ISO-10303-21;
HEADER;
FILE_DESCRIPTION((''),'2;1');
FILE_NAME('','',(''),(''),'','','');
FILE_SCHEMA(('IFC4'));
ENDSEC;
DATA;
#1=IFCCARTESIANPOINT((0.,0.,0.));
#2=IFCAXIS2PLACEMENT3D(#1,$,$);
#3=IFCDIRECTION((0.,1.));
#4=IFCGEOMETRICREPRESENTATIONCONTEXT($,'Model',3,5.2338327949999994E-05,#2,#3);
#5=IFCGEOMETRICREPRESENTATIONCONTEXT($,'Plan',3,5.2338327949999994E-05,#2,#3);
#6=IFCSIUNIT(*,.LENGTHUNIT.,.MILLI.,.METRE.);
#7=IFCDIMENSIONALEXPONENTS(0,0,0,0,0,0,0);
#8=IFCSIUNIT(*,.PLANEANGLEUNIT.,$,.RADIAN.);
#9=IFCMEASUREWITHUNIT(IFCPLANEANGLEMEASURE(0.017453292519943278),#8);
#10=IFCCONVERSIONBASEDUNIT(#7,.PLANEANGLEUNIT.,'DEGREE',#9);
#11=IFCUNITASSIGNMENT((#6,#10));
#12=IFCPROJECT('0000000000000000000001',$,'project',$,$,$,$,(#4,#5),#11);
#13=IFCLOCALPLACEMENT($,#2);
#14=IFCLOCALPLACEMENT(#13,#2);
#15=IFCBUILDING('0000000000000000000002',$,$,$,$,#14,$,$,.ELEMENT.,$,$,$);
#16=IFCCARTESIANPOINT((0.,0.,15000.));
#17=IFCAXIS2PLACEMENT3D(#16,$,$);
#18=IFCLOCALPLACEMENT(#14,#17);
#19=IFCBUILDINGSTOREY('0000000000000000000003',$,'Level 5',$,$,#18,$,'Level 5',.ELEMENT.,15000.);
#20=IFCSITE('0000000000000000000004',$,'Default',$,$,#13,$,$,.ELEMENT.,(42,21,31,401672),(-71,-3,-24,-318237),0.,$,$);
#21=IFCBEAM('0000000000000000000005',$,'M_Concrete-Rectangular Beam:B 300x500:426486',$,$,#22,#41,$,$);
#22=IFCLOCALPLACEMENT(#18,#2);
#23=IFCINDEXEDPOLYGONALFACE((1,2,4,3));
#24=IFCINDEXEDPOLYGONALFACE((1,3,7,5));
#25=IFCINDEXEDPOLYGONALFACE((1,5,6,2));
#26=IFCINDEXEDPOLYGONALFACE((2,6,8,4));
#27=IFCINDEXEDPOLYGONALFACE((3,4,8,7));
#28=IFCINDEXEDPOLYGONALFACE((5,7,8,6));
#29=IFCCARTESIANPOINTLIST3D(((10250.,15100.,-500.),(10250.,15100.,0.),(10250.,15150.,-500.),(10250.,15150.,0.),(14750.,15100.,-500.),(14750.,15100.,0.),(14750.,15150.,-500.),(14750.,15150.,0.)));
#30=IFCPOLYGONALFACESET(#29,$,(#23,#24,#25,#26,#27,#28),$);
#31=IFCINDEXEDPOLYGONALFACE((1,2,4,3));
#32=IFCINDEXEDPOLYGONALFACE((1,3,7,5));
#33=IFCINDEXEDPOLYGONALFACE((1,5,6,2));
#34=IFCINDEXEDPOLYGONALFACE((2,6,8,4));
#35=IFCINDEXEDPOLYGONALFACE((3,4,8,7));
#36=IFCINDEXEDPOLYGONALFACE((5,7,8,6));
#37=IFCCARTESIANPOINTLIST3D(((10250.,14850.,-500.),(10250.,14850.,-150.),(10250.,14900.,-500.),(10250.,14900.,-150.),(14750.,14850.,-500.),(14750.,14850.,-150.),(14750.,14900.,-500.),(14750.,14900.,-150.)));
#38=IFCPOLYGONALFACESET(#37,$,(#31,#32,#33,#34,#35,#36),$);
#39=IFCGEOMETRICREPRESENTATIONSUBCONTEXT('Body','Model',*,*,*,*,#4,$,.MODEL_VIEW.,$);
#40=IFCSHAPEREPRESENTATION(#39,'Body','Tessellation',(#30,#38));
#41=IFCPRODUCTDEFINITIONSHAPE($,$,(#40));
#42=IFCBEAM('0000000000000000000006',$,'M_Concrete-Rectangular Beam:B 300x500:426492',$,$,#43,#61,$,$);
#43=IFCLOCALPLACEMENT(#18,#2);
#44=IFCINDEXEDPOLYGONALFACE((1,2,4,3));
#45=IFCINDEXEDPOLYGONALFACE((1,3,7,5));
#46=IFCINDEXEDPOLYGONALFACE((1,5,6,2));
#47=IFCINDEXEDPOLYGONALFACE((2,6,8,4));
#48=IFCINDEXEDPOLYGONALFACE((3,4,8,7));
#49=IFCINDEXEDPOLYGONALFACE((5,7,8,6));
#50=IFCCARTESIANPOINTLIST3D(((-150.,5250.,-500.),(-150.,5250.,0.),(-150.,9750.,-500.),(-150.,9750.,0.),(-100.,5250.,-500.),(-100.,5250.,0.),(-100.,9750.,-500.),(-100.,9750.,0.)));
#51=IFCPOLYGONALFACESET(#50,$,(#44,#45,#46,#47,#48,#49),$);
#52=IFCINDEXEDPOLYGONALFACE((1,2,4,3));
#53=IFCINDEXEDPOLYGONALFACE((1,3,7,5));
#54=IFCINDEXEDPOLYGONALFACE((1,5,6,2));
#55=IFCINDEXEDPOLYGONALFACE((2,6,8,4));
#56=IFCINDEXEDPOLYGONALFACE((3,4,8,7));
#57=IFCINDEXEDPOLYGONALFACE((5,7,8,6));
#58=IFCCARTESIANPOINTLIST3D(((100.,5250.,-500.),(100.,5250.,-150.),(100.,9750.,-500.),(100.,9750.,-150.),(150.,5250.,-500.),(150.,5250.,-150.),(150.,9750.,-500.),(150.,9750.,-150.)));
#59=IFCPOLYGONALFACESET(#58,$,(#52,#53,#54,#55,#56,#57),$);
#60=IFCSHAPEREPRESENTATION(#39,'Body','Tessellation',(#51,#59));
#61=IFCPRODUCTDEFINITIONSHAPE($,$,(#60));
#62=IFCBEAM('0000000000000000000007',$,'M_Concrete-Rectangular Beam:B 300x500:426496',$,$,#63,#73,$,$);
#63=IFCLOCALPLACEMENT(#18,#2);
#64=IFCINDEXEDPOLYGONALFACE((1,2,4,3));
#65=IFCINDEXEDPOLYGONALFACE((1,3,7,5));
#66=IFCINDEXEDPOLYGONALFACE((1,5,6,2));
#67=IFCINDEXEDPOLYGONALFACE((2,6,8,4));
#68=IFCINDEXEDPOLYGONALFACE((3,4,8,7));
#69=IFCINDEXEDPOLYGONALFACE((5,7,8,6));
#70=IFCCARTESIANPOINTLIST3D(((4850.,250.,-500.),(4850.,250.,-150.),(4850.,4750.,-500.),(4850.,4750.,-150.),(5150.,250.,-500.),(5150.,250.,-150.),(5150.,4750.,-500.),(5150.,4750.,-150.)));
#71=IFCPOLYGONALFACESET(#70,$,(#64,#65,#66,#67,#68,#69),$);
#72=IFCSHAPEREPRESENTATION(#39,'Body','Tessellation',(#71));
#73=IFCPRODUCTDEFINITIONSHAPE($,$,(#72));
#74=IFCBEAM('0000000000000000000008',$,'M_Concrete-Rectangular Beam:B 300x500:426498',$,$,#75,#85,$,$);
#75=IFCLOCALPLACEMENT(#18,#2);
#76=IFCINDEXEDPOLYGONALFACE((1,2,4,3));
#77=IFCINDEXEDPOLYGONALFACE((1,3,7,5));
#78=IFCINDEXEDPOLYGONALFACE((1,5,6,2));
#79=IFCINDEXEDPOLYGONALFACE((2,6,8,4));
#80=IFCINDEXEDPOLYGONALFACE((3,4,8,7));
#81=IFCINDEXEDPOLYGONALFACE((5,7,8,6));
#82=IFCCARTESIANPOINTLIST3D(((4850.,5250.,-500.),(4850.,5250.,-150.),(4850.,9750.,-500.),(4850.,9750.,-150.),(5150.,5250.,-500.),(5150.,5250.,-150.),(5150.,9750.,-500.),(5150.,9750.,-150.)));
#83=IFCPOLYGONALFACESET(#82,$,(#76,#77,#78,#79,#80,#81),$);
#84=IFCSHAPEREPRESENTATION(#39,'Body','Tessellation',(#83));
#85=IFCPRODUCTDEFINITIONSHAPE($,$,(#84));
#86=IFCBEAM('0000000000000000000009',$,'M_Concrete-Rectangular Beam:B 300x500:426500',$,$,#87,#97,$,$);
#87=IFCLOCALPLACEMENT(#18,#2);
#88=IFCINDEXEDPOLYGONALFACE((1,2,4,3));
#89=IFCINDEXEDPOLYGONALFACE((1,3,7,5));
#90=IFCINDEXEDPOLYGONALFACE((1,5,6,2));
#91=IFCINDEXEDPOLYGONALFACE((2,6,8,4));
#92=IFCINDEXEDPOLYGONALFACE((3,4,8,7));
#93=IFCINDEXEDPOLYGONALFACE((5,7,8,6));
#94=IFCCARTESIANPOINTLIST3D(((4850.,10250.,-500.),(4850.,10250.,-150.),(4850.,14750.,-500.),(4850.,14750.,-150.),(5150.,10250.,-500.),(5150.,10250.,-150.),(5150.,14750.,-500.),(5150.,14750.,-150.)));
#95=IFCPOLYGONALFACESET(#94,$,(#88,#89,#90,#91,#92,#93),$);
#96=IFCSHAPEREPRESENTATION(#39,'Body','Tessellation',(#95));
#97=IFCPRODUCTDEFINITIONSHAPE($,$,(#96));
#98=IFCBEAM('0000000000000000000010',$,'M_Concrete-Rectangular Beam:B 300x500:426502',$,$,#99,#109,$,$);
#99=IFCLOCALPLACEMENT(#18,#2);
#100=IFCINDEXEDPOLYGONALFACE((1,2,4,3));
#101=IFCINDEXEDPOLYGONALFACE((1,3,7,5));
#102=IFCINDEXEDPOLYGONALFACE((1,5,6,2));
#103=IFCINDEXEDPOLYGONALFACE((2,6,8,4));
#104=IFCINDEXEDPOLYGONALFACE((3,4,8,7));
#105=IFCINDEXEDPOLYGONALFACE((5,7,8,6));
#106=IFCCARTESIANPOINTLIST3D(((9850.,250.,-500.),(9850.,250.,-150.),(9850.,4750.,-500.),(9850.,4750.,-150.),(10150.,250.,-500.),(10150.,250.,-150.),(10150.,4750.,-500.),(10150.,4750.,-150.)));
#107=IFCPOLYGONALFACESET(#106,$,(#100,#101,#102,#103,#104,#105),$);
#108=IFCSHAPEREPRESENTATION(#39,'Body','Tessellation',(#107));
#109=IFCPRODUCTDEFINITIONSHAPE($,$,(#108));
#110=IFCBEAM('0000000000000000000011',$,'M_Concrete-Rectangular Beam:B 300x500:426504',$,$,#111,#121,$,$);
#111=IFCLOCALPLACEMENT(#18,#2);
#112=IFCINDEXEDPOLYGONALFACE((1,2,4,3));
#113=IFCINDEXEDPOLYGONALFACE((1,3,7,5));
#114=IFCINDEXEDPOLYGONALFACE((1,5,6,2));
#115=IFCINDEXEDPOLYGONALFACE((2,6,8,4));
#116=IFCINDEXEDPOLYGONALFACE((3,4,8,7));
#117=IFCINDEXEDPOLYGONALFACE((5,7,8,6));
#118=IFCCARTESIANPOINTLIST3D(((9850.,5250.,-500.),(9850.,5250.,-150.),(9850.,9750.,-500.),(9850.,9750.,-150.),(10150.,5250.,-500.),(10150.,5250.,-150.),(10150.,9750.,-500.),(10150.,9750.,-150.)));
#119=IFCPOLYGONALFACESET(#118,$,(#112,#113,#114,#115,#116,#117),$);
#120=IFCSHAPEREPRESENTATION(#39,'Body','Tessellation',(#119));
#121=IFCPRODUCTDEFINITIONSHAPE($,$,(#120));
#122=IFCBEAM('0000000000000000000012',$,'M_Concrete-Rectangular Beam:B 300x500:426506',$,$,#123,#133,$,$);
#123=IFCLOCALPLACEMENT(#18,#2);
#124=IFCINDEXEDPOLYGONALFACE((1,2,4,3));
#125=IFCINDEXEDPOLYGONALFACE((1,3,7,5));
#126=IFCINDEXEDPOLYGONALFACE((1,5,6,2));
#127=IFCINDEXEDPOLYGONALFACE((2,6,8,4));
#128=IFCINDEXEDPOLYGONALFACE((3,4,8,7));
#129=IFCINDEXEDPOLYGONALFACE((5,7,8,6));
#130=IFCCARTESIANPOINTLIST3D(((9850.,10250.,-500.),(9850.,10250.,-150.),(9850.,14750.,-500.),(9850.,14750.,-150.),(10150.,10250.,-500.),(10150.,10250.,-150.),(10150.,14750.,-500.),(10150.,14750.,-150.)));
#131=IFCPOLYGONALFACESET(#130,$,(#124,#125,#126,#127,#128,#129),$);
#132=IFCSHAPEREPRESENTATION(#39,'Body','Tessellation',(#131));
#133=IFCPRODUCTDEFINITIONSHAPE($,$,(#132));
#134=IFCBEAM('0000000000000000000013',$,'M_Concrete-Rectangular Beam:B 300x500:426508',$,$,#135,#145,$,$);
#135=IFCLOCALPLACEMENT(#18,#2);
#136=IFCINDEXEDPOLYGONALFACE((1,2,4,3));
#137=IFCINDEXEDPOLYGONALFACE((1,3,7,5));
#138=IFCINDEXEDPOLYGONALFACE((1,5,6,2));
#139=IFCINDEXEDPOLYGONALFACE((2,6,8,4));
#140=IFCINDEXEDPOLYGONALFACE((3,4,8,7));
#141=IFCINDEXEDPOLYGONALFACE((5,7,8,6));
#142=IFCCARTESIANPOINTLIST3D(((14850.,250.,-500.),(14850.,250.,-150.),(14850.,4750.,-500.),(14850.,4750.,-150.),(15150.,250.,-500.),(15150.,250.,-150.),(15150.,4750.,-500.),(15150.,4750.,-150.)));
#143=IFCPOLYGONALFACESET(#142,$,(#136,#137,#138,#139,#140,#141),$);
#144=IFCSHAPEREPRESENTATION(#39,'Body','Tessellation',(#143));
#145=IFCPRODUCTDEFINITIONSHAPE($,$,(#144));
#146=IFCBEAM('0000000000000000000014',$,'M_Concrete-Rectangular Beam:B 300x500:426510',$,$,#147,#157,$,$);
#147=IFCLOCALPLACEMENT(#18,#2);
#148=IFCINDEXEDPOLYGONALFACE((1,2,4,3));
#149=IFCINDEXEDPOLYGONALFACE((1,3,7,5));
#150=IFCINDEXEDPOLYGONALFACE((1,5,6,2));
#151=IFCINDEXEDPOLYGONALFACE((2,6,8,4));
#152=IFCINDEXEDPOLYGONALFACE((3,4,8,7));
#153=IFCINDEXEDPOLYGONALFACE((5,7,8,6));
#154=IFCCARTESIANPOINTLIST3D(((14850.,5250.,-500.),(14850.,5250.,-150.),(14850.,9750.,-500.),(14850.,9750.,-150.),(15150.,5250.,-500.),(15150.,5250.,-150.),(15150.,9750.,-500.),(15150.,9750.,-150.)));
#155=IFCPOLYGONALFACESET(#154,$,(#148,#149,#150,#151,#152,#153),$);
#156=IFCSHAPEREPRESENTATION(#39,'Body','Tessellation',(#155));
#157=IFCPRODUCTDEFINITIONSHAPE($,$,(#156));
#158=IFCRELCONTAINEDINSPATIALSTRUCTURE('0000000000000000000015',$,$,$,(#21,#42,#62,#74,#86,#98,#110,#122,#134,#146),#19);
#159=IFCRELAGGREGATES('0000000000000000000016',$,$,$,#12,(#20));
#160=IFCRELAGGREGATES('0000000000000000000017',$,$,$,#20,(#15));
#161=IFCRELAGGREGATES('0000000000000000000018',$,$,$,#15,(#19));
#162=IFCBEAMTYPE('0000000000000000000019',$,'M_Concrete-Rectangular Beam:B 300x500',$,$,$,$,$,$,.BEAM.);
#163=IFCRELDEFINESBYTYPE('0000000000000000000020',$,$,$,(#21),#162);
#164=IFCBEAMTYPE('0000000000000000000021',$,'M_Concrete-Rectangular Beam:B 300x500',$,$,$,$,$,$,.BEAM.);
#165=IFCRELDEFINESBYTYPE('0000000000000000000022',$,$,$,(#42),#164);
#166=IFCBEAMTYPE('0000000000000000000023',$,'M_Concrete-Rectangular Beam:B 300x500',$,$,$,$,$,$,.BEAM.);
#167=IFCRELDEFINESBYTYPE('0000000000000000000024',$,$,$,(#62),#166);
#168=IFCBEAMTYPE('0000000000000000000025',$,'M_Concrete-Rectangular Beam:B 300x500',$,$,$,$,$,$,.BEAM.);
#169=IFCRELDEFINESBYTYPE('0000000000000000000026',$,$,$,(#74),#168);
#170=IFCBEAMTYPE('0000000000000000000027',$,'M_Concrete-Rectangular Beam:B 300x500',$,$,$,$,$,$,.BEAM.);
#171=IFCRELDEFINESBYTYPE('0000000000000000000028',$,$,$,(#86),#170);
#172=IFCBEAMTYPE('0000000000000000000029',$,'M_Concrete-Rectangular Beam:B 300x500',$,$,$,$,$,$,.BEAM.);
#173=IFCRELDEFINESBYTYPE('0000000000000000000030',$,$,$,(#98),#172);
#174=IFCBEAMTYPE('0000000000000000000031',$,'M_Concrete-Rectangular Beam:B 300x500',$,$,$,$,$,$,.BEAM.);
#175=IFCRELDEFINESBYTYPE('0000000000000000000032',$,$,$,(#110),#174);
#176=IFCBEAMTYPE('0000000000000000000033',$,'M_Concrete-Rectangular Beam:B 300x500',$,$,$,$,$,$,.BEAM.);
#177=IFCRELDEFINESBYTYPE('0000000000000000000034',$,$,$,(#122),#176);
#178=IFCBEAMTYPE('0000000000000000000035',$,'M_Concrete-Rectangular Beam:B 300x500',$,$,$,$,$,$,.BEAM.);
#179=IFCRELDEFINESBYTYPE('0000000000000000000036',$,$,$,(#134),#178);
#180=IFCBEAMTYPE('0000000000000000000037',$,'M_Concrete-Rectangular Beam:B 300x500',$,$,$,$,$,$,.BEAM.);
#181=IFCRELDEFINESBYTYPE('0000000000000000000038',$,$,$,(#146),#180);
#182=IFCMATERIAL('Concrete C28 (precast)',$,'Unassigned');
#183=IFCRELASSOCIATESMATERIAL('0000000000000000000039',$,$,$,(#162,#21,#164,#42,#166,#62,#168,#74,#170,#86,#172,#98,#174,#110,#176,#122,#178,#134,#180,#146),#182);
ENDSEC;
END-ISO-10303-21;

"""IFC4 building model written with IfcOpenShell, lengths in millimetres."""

from ifc_helpers import new_model, entity, si_unit, converted_unit, direction, frame, origin, place, context, subcontext, project, spatial, indexed_curve, outline, extrude, source, transform, mapped, material, type_object, type_shapes, element, save


model = new_model("IFC4")

# Units and contexts
model_context = context("Model", 3, precision=5.2338327949999994e-05, world=origin(), true_north=direction((0.0, 1.0)))
plan_context = context("Plan", 3, precision=5.2338327949999994e-05, world=origin(), true_north=direction((0.0, 1.0)))
body_context = subcontext(model_context, "Body", "Model", "MODEL_VIEW")
ifc_project = project(units=[si_unit("LENGTHUNIT", "METRE", prefix="MILLI"), converted_unit("PLANEANGLEUNIT", "DEGREE", entity("IfcPlaneAngleMeasure", 0.017453292519943278), si_unit("PLANEANGLEUNIT", "RADIAN"), dimensions=[0, 0, 0, 0, 0, 0, 0])], contexts=[model_context, plan_context])

# Site, building, storey
site_placement = place(None, origin())
site = spatial("IfcSite", under=ifc_project, at=site_placement, Name="Default", CompositionType="ELEMENT", RefLatitude=(42, 21, 31, 401672), RefLongitude=(-71, -3, -24, -318237), RefElevation=0.0)
building_placement = place(site_placement, origin())
building = spatial("IfcBuilding", under=site, at=building_placement, CompositionType="ELEMENT")
storey_placement = place(building_placement, frame((0.0, 0.0, 15000.0)))
storey = spatial("IfcBuildingStorey", under=building, at=storey_placement, Name="Level 5", LongName="Level 5", CompositionType="ELEMENT", Elevation=15000.0)

# Beams
ifc_material = material(Name="Concrete C28 (precast)", Category="Unassigned")
beam_type_1 = type_object("IfcBeamType", Name="M_Concrete-Rectangular Beam:B 300x500", PredefinedType="BEAM", material=ifc_material)
shared_shape_1 = source(origin(), body_context, "Body", "SweptSolid", [
    extrude(outline(indexed_curve([(-250.0, -25.0), (250.0, -25.0), (250.0, 25.0), (-250.0, 25.0), (-250.0, -25.0)], self_intersect=False)), frame((10250.0, 15125.0, 14750.0), z_axis=(1.0, 0.0, 0.0), x_axis=(0.0, 0.0, -1.0)), (0.0, 0.0, 1.0), 4500.0),
    extrude(outline(indexed_curve([(-175.0, -25.0), (175.0, -25.0), (175.0, 25.0), (-175.0, 25.0), (-175.0, -25.0)], self_intersect=False)), frame((10250.0, 14875.0, 14675.0), z_axis=(1.0, 0.0, 0.0), x_axis=(0.0, 0.0, -1.0)), (0.0, 0.0, 1.0), 4500.0),
])
type_shapes(beam_type_1, [shared_shape_1])
beam_1_placement = place(storey_placement, frame((0.0, 0.0, -15000.0)))
element("IfcBeam", 1, at=beam_1_placement, inside=storey, type_object=beam_type_1, material=ifc_material, Name="M_Concrete-Rectangular Beam:B 300x500:426486", context=body_context, shape_type="MappedRepresentation", body=[
    mapped(shared_shape_1, transform((0.0, 0.0, 0.0), scale=1.0)),
])
beam_type_2 = type_object("IfcBeamType", Name="M_Concrete-Rectangular Beam:B 300x500", PredefinedType="BEAM", material=ifc_material)
shared_shape_2 = source(origin(), body_context, "Body", "SweptSolid", [
    extrude(outline(indexed_curve([(-25.0, -250.0), (25.0, -250.0), (25.0, 250.0), (-25.0, 250.0), (-25.0, -250.0)], self_intersect=False)), frame((-125.0, 5250.0, 14750.0), z_axis=(0.0, 1.0, 0.0), x_axis=(-1.0, 0.0, 0.0)), (0.0, 0.0, 1.0), 4500.0),
    extrude(outline(indexed_curve([(-25.0, -175.0), (25.0, -175.0), (25.0, 175.0), (-25.0, 175.0), (-25.0, -175.0)], self_intersect=False)), frame((125.0, 5250.0, 14675.0), z_axis=(0.0, 1.0, 0.0), x_axis=(-1.0, 0.0, 0.0)), (0.0, 0.0, 1.0), 4500.0),
])
type_shapes(beam_type_2, [shared_shape_2])
beam_2_placement = place(storey_placement, frame((0.0, 0.0, -15000.0)))
element("IfcBeam", 2, at=beam_2_placement, inside=storey, type_object=beam_type_2, material=ifc_material, Name="M_Concrete-Rectangular Beam:B 300x500:426492", context=body_context, shape_type="MappedRepresentation", body=[
    mapped(shared_shape_2, transform((0.0, 0.0, 0.0), scale=1.0)),
])
beam_type_3 = type_object("IfcBeamType", Name="M_Concrete-Rectangular Beam:B 300x500", PredefinedType="BEAM", material=ifc_material)
shared_shape_3 = source(origin(), body_context, "Body", "SweptSolid", [
    extrude(outline(indexed_curve([(-150.0, -175.0), (150.0, -175.0), (150.0, 175.0), (-150.0, 175.0), (-150.0, -175.0)], self_intersect=False)), frame((5000.0, 250.0, 14675.0), z_axis=(0.0, 1.0, 0.0), x_axis=(-1.0, 0.0, 0.0)), (0.0, 0.0, 1.0), 4500.0),
])
type_shapes(beam_type_3, [shared_shape_3])
beam_3_placement = place(storey_placement, frame((0.0, 0.0, -15000.0)))
element("IfcBeam", 3, at=beam_3_placement, inside=storey, type_object=beam_type_3, material=ifc_material, Name="M_Concrete-Rectangular Beam:B 300x500:426496", context=body_context, shape_type="MappedRepresentation", body=[
    mapped(shared_shape_3, transform((0.0, 0.0, 0.0), scale=1.0)),
])
beam_type_4 = type_object("IfcBeamType", Name="M_Concrete-Rectangular Beam:B 300x500", PredefinedType="BEAM", material=ifc_material)
shared_shape_4 = source(origin(), body_context, "Body", "SweptSolid", [
    extrude(outline(indexed_curve([(-150.0, -175.0), (150.0, -175.0), (150.0, 175.0), (-150.0, 175.0), (-150.0, -175.0)], self_intersect=False)), frame((5000.0, 5250.0, 14675.0), z_axis=(0.0, 1.0, 0.0), x_axis=(-1.0, 0.0, 0.0)), (0.0, 0.0, 1.0), 4500.0),
])
type_shapes(beam_type_4, [shared_shape_4])
beam_4_placement = place(storey_placement, frame((0.0, 0.0, -15000.0)))
element("IfcBeam", 4, at=beam_4_placement, inside=storey, type_object=beam_type_4, material=ifc_material, Name="M_Concrete-Rectangular Beam:B 300x500:426498", context=body_context, shape_type="MappedRepresentation", body=[
    mapped(shared_shape_4, transform((0.0, 0.0, 0.0), scale=1.0)),
])
beam_type_5 = type_object("IfcBeamType", Name="M_Concrete-Rectangular Beam:B 300x500", PredefinedType="BEAM", material=ifc_material)
shared_shape_5 = source(origin(), body_context, "Body", "SweptSolid", [
    extrude(outline(indexed_curve([(-150.0, -175.0), (150.0, -175.0), (150.0, 175.0), (-150.0, 175.0), (-150.0, -175.0)], self_intersect=False)), frame((5000.0, 10250.0, 14675.0), z_axis=(0.0, 1.0, 0.0), x_axis=(-1.0, 0.0, 0.0)), (0.0, 0.0, 1.0), 4500.0),
])
type_shapes(beam_type_5, [shared_shape_5])
beam_5_placement = place(storey_placement, frame((0.0, 0.0, -15000.0)))
element("IfcBeam", 5, at=beam_5_placement, inside=storey, type_object=beam_type_5, material=ifc_material, Name="M_Concrete-Rectangular Beam:B 300x500:426500", context=body_context, shape_type="MappedRepresentation", body=[
    mapped(shared_shape_5, transform((0.0, 0.0, 0.0), scale=1.0)),
])
beam_type_6 = type_object("IfcBeamType", Name="M_Concrete-Rectangular Beam:B 300x500", PredefinedType="BEAM", material=ifc_material)
shared_shape_6 = source(origin(), body_context, "Body", "SweptSolid", [
    extrude(outline(indexed_curve([(-150.0, -175.0), (150.0, -175.0), (150.0, 175.0), (-150.0, 175.0), (-150.0, -175.0)], self_intersect=False)), frame((10000.0, 250.0, 14675.0), z_axis=(0.0, 1.0, 0.0), x_axis=(-1.0, 0.0, 0.0)), (0.0, 0.0, 1.0), 4500.0),
])
type_shapes(beam_type_6, [shared_shape_6])
beam_6_placement = place(storey_placement, frame((0.0, 0.0, -15000.0)))
element("IfcBeam", 6, at=beam_6_placement, inside=storey, type_object=beam_type_6, material=ifc_material, Name="M_Concrete-Rectangular Beam:B 300x500:426502", context=body_context, shape_type="MappedRepresentation", body=[
    mapped(shared_shape_6, transform((0.0, 0.0, 0.0), scale=1.0)),
])
beam_type_7 = type_object("IfcBeamType", Name="M_Concrete-Rectangular Beam:B 300x500", PredefinedType="BEAM", material=ifc_material)
shared_shape_7 = source(origin(), body_context, "Body", "SweptSolid", [
    extrude(outline(indexed_curve([(-150.0, -175.0), (150.0, -175.0), (150.0, 175.0), (-150.0, 175.0), (-150.0, -175.0)], self_intersect=False)), frame((10000.0, 5250.0, 14675.0), z_axis=(0.0, 1.0, 0.0), x_axis=(-1.0, 0.0, 0.0)), (0.0, 0.0, 1.0), 4500.0),
])
type_shapes(beam_type_7, [shared_shape_7])
beam_7_placement = place(storey_placement, frame((0.0, 0.0, -15000.0)))
element("IfcBeam", 7, at=beam_7_placement, inside=storey, type_object=beam_type_7, material=ifc_material, Name="M_Concrete-Rectangular Beam:B 300x500:426504", context=body_context, shape_type="MappedRepresentation", body=[
    mapped(shared_shape_7, transform((0.0, 0.0, 0.0), scale=1.0)),
])
beam_type_8 = type_object("IfcBeamType", Name="M_Concrete-Rectangular Beam:B 300x500", PredefinedType="BEAM", material=ifc_material)
shared_shape_8 = source(origin(), body_context, "Body", "SweptSolid", [
    extrude(outline(indexed_curve([(-150.0, -175.0), (150.0, -175.0), (150.0, 175.0), (-150.0, 175.0), (-150.0, -175.0)], self_intersect=False)), frame((10000.0, 10250.0, 14675.0), z_axis=(0.0, 1.0, 0.0), x_axis=(-1.0, 0.0, 0.0)), (0.0, 0.0, 1.0), 4500.0),
])
type_shapes(beam_type_8, [shared_shape_8])
beam_8_placement = place(storey_placement, frame((0.0, 0.0, -15000.0)))
element("IfcBeam", 8, at=beam_8_placement, inside=storey, type_object=beam_type_8, material=ifc_material, Name="M_Concrete-Rectangular Beam:B 300x500:426506", context=body_context, shape_type="MappedRepresentation", body=[
    mapped(shared_shape_8, transform((0.0, 0.0, 0.0), scale=1.0)),
])
beam_type_9 = type_object("IfcBeamType", Name="M_Concrete-Rectangular Beam:B 300x500", PredefinedType="BEAM", material=ifc_material)
shared_shape_9 = source(origin(), body_context, "Body", "SweptSolid", [
    extrude(outline(indexed_curve([(-150.0, -175.0), (150.0, -175.0), (150.0, 175.0), (-150.0, 175.0), (-150.0, -175.0)], self_intersect=False)), frame((15000.0, 250.0, 14675.0), z_axis=(0.0, 1.0, 0.0), x_axis=(-1.0, 0.0, 0.0)), (0.0, 0.0, 1.0), 4500.0),
])
type_shapes(beam_type_9, [shared_shape_9])
beam_9_placement = place(storey_placement, frame((0.0, 0.0, -15000.0)))
element("IfcBeam", 9, at=beam_9_placement, inside=storey, type_object=beam_type_9, material=ifc_material, Name="M_Concrete-Rectangular Beam:B 300x500:426508", context=body_context, shape_type="MappedRepresentation", body=[
    mapped(shared_shape_9, transform((0.0, 0.0, 0.0), scale=1.0)),
])
beam_type_10 = type_object("IfcBeamType", Name="M_Concrete-Rectangular Beam:B 300x500", PredefinedType="BEAM", material=ifc_material)
shared_shape_10 = source(origin(), body_context, "Body", "SweptSolid", [
    extrude(outline(indexed_curve([(-150.0, -175.0), (150.0, -175.0), (150.0, 175.0), (-150.0, 175.0), (-150.0, -175.0)], self_intersect=False)), frame((15000.0, 5250.0, 14675.0), z_axis=(0.0, 1.0, 0.0), x_axis=(-1.0, 0.0, 0.0)), (0.0, 0.0, 1.0), 4500.0),
])
type_shapes(beam_type_10, [shared_shape_10])
beam_10_placement = place(storey_placement, frame((0.0, 0.0, -15000.0)))
element("IfcBeam", 10, at=beam_10_placement, inside=storey, type_object=beam_type_10, material=ifc_material, Name="M_Concrete-Rectangular Beam:B 300x500:426510", context=body_context, shape_type="MappedRepresentation", body=[
    mapped(shared_shape_10, transform((0.0, 0.0, 0.0), scale=1.0)),
])

save(model, "model.ifc")
